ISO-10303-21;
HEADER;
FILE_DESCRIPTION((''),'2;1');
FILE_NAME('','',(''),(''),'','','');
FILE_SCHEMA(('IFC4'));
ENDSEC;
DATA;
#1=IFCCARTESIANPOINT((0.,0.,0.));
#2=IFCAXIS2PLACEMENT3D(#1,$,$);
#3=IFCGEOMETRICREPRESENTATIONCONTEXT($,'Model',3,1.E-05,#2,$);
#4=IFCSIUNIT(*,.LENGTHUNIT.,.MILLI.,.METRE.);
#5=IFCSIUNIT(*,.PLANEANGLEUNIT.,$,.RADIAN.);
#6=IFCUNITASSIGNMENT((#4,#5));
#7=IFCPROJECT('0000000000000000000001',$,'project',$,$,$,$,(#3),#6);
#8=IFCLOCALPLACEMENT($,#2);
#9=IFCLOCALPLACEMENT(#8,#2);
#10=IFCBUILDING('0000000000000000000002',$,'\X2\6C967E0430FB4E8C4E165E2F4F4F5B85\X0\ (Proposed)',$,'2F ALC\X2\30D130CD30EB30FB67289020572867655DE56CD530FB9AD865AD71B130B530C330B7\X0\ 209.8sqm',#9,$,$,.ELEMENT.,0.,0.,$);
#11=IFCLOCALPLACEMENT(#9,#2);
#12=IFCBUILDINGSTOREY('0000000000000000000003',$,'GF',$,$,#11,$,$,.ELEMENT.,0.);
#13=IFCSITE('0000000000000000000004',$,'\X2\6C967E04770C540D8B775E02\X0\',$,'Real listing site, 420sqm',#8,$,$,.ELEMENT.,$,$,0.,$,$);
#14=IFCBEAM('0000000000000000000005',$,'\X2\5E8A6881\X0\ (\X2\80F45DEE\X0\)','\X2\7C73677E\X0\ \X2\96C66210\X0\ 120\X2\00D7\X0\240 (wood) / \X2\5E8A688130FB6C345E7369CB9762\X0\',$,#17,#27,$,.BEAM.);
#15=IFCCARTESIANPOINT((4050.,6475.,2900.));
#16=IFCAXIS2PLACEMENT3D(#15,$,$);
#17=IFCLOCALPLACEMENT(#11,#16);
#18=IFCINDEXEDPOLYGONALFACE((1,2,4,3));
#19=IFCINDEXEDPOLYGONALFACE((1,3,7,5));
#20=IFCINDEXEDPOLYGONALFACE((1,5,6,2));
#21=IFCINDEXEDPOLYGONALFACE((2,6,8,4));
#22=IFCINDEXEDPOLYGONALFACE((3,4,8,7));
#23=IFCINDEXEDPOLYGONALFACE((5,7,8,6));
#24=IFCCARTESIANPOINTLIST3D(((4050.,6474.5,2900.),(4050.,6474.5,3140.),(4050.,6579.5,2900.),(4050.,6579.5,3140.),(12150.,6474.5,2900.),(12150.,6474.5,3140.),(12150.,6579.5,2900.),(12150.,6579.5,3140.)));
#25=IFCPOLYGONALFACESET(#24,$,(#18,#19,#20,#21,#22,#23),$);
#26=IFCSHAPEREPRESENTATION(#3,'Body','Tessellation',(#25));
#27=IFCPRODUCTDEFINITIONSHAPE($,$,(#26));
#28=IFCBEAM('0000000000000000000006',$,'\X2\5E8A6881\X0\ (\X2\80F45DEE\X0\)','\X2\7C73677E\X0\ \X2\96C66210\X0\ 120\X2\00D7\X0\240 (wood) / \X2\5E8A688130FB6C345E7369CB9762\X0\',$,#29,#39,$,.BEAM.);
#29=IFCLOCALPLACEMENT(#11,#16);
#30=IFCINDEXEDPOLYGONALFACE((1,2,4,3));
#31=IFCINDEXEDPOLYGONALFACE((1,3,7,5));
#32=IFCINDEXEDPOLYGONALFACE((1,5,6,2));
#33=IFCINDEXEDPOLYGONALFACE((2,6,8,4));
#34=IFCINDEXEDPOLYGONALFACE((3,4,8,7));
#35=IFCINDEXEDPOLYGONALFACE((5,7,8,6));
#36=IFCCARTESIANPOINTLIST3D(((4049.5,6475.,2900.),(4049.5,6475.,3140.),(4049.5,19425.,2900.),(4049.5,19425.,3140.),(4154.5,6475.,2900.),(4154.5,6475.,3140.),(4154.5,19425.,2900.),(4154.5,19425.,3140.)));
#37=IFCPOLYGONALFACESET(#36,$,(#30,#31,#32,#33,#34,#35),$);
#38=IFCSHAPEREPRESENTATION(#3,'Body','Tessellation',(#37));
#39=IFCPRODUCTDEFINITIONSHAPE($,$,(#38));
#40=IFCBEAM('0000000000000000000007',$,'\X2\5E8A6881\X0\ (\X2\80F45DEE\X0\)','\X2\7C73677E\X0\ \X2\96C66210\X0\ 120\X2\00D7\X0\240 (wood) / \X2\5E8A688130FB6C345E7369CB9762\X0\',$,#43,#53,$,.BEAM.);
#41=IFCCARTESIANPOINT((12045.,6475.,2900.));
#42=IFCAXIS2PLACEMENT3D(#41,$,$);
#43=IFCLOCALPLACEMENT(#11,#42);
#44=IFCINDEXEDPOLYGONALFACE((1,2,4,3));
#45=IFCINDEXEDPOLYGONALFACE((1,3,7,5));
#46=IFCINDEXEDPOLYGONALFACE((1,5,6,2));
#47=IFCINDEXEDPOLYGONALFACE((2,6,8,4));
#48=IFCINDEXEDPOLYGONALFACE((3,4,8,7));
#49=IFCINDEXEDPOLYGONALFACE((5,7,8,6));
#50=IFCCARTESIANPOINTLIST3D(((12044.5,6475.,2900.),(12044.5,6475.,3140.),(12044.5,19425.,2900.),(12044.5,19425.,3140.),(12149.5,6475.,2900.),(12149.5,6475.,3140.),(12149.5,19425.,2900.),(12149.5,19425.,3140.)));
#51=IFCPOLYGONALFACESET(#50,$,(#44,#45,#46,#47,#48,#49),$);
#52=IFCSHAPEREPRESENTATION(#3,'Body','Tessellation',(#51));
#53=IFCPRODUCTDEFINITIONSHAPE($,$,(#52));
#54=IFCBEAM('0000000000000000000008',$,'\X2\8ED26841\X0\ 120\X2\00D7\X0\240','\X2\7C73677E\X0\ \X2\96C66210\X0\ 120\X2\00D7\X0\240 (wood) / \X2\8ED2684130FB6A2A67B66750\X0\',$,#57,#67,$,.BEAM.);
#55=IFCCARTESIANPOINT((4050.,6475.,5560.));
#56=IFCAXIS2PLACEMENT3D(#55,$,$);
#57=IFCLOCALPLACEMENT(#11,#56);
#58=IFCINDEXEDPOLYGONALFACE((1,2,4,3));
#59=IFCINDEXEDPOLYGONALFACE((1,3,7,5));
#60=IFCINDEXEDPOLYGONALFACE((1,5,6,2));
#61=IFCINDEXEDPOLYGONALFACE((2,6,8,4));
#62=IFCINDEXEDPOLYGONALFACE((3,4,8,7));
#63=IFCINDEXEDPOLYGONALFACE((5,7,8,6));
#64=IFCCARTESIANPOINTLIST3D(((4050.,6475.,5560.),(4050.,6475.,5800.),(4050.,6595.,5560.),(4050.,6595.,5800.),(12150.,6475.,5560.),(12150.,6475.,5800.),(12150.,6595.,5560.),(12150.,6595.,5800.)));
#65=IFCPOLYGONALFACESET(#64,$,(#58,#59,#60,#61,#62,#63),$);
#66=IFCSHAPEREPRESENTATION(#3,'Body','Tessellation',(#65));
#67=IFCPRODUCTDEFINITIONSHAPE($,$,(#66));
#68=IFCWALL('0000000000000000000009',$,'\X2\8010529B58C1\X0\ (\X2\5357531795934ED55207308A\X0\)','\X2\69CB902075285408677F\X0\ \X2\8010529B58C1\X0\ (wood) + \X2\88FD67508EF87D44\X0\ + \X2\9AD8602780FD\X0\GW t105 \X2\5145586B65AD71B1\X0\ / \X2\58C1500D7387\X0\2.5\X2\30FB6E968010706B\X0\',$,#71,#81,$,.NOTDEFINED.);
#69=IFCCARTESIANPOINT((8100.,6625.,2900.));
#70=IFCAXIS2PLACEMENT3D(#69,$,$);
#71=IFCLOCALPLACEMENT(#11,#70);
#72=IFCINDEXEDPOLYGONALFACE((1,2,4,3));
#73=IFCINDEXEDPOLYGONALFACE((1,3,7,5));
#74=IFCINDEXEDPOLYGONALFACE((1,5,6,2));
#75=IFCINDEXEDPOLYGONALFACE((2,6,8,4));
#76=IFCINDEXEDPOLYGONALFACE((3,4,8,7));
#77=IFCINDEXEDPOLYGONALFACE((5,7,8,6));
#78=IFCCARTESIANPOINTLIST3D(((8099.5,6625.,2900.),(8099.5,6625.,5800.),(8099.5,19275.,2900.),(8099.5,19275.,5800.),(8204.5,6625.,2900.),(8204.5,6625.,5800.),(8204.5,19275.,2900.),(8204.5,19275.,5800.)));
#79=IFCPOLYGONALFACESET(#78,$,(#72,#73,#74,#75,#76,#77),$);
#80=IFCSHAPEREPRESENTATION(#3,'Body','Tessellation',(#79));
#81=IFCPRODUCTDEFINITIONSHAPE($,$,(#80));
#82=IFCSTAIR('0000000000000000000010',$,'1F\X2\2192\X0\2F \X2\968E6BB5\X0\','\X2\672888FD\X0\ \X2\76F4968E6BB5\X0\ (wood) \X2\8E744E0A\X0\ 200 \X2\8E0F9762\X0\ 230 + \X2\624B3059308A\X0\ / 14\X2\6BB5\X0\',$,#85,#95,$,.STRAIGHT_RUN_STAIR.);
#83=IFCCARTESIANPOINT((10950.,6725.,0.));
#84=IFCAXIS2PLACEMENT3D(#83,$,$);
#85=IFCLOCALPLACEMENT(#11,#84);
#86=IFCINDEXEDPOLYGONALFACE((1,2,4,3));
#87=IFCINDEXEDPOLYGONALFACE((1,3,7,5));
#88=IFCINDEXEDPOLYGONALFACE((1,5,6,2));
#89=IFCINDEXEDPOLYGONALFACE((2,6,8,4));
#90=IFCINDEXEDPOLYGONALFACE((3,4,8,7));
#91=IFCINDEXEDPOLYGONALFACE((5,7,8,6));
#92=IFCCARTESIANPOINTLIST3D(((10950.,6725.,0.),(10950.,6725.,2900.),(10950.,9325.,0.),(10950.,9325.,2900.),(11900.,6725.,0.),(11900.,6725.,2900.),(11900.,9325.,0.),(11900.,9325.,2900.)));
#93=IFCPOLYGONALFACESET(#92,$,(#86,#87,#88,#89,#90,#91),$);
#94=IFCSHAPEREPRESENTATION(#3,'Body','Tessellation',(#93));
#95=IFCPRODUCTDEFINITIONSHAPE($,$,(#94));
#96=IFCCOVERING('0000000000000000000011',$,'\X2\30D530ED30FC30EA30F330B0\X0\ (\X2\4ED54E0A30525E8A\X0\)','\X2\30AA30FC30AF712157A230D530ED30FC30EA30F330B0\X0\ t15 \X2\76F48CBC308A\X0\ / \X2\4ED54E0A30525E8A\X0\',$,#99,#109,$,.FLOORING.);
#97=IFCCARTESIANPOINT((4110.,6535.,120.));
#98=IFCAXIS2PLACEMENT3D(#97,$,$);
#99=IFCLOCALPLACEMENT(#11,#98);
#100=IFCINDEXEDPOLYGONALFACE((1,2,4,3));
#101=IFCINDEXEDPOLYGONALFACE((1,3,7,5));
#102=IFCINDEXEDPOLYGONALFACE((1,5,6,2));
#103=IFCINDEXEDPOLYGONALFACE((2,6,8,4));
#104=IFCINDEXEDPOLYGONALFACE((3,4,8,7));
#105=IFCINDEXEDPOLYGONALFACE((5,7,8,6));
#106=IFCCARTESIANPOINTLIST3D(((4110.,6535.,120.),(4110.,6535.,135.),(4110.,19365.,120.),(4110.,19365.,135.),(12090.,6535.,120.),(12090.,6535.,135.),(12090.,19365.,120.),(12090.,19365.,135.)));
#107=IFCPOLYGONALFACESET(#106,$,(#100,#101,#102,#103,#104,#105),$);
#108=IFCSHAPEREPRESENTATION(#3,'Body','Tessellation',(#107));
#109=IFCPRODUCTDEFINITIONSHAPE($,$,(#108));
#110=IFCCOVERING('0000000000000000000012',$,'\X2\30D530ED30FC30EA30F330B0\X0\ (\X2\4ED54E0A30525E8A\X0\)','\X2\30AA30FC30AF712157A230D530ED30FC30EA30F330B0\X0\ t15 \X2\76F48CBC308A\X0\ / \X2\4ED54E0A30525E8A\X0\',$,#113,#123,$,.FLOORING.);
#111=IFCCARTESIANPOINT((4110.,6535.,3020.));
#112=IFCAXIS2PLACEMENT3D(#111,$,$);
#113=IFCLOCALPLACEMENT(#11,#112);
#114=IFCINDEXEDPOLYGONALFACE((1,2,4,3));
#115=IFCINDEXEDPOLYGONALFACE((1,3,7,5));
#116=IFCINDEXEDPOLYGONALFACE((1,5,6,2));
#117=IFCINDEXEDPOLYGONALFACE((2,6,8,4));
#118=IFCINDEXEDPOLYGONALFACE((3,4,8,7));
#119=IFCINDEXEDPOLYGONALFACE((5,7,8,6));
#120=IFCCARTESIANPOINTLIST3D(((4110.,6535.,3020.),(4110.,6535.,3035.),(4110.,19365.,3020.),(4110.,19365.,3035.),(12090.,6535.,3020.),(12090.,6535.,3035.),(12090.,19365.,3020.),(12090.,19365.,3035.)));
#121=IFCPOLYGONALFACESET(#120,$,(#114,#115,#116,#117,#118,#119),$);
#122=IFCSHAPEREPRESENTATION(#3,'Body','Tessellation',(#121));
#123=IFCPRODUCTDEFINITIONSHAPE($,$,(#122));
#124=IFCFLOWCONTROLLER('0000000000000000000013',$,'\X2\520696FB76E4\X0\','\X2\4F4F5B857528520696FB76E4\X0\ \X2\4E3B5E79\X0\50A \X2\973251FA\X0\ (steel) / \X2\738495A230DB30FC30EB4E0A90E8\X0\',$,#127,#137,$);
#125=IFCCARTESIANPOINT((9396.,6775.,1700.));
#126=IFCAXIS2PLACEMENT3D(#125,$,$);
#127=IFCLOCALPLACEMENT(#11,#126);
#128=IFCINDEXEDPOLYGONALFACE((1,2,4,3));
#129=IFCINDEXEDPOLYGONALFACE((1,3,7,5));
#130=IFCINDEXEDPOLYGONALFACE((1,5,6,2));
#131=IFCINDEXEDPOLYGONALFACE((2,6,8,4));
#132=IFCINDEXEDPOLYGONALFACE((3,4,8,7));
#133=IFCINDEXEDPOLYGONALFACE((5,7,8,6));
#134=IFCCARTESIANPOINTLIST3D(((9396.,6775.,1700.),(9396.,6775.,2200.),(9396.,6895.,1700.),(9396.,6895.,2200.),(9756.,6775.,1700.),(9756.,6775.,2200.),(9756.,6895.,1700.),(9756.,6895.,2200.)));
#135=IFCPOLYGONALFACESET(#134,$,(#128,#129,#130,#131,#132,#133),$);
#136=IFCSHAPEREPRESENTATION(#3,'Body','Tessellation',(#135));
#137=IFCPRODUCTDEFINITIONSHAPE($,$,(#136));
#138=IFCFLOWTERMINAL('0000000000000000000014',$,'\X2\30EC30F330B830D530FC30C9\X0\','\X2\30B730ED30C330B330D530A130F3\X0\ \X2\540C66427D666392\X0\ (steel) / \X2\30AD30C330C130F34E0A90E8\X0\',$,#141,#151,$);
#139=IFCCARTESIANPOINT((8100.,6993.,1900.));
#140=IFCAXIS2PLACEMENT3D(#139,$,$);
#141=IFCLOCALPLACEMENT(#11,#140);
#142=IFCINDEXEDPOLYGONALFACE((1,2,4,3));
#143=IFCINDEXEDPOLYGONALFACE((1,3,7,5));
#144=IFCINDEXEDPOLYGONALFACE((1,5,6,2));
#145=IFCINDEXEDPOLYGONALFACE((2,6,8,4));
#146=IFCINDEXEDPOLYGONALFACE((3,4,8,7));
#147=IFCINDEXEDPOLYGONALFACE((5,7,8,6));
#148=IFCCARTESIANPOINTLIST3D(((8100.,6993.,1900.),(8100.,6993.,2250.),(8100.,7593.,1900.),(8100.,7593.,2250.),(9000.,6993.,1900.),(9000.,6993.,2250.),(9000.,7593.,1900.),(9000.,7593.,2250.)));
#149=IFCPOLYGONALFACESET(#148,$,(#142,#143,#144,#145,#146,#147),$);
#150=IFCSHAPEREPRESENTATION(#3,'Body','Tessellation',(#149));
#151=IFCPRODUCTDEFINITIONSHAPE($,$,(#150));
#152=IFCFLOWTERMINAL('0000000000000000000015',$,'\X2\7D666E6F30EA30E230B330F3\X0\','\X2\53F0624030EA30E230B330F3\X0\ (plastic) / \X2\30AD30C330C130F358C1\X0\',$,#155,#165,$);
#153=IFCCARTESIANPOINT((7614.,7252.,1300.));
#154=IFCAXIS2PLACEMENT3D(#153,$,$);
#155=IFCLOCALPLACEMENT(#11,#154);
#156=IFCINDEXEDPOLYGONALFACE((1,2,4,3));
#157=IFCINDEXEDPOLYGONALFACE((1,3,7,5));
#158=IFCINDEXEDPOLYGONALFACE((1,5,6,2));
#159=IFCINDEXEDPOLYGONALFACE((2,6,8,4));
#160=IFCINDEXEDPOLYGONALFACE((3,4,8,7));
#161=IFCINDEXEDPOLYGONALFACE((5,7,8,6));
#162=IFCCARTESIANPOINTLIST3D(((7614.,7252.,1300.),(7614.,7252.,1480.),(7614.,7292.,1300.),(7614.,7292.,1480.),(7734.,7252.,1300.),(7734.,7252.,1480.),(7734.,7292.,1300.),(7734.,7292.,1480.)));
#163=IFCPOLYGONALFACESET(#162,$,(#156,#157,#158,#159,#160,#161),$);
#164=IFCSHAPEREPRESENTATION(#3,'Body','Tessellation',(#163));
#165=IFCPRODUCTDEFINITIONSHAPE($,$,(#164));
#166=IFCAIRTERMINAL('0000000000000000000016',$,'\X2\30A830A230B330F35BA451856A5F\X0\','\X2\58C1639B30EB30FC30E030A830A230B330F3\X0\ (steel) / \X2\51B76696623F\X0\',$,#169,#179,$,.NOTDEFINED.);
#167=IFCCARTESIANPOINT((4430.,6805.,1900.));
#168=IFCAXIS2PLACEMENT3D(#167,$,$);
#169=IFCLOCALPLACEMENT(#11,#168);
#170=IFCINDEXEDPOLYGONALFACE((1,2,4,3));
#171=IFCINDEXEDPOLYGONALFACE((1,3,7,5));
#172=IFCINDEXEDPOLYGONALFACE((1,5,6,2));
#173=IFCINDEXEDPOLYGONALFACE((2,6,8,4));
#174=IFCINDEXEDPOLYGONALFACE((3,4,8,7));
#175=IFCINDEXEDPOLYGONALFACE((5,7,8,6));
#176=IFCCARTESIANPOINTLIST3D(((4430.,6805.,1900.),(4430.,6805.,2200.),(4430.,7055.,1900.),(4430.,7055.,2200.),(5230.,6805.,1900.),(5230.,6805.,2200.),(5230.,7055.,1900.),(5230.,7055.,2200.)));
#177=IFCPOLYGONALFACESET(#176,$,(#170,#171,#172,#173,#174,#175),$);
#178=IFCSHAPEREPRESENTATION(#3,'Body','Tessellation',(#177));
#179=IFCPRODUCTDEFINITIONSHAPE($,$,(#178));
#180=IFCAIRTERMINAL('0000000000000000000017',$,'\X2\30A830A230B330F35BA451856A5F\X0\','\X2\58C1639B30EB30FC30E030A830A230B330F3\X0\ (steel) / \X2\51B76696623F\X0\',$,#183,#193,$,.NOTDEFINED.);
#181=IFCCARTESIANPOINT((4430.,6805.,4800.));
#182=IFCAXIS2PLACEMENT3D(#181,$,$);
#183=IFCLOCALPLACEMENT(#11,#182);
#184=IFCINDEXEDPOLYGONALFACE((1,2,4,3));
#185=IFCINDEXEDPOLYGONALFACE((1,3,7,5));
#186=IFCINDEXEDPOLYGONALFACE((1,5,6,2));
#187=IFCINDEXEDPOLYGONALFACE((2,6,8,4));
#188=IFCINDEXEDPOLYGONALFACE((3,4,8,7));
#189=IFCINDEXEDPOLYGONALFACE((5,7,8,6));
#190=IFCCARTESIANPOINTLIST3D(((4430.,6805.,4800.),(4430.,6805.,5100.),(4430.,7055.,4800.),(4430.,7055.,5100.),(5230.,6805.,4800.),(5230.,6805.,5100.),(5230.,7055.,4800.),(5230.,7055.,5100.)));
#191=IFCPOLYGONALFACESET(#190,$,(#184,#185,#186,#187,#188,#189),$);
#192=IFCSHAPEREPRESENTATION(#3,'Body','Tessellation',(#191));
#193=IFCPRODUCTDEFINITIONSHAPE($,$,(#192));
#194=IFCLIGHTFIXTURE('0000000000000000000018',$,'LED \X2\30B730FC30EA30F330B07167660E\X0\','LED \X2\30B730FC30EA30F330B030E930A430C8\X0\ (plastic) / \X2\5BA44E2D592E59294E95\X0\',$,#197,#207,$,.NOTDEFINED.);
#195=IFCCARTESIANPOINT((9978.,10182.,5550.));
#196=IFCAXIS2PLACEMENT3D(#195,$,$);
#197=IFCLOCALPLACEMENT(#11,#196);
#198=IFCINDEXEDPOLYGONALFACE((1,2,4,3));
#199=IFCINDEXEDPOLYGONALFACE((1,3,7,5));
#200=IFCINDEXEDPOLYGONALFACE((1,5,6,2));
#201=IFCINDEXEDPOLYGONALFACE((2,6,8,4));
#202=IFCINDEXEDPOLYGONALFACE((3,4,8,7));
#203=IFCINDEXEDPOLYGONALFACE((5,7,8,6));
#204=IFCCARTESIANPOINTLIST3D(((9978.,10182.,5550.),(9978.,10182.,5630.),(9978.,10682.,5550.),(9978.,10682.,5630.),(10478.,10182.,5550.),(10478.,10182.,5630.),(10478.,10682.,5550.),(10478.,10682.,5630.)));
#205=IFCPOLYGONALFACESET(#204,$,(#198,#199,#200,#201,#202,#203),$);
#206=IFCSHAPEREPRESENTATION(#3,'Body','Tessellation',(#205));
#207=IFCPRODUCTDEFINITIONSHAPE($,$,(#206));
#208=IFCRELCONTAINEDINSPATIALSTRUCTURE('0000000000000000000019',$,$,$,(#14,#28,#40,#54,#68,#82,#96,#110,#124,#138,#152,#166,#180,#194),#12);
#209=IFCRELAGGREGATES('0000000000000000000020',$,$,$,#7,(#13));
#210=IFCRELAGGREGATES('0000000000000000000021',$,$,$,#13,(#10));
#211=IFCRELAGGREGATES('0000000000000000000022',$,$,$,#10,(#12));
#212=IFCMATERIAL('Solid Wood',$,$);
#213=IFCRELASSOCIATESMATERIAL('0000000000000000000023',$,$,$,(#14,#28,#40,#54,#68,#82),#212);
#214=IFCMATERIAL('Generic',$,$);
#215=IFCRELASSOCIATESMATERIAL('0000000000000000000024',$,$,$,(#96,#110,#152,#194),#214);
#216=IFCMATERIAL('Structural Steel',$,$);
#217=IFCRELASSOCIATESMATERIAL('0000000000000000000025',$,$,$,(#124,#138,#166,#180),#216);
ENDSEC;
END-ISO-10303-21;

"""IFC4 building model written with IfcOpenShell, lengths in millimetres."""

from ifc_helpers import new_model, si_unit, frame, frame_2d, origin, place, context, project, spatial, rectangle, extrude, material, element, save


model = new_model("IFC4")

# Units and contexts
model_context = context("Model", 3, precision=1e-05, world=origin())
ifc_project = project(units=[si_unit("LENGTHUNIT", "METRE", prefix="MILLI"), si_unit("PLANEANGLEUNIT", "RADIAN")], contexts=[model_context])

# Site, building, storey
site_placement = place(None, origin())
site = spatial("IfcSite", under=ifc_project, at=site_placement, Name="沖縄県名護市", ObjectType="Real listing site, 420sqm", CompositionType="ELEMENT", RefElevation=0.0)
building_placement = place(site_placement, origin())
building = spatial("IfcBuilding", under=site, at=building_placement, Name="沖縄・二世帯住宅 (Proposed)", ObjectType="2F ALCパネル・木造在来工法・高断熱サッシ 209.8sqm", CompositionType="ELEMENT", ElevationOfRefHeight=0.0, ElevationOfTerrain=0.0)
storey_placement = place(building_placement, origin())
storey = spatial("IfcBuildingStorey", under=building, at=storey_placement, Name="GF", CompositionType="ELEMENT", Elevation=0.0)

# Shared definitions
ifc_material_1 = material(Name="Solid Wood")

# Beams
beam_1_placement = place(storey_placement, frame((4050.0, 6475.0, 2900.0)))
element("IfcBeam", 1, at=beam_1_placement, inside=storey, material=ifc_material_1, Name="床梁 (胴差)", Description="米松 集成 120×240 (wood) / 床梁・水平構面", PredefinedType="BEAM", context=model_context, shape_type="SweptSolid", body=[
    extrude(rectangle(XDim=8100.0, YDim=105.0, at=frame_2d((4050.0, 52.0))), frame((4050.0, 6475.0, 2900.0)), (0.0, 0.0, 1.0), 240.0),
])
beam_2_placement = place(storey_placement, frame((4050.0, 6475.0, 2900.0)))
element("IfcBeam", 2, at=beam_2_placement, inside=storey, material=ifc_material_1, Name="床梁 (胴差)", Description="米松 集成 120×240 (wood) / 床梁・水平構面", PredefinedType="BEAM", context=model_context, shape_type="SweptSolid", body=[
    extrude(rectangle(XDim=105.0, YDim=12950.0, at=frame_2d((52.0, 6475.0))), frame((4050.0, 6475.0, 2900.0)), (0.0, 0.0, 1.0), 240.0),
])
beam_3_placement = place(storey_placement, frame((12045.0, 6475.0, 2900.0)))
element("IfcBeam", 3, at=beam_3_placement, inside=storey, material=ifc_material_1, Name="床梁 (胴差)", Description="米松 集成 120×240 (wood) / 床梁・水平構面", PredefinedType="BEAM", context=model_context, shape_type="SweptSolid", body=[
    extrude(rectangle(XDim=105.0, YDim=12950.0, at=frame_2d((52.0, 6475.0))), frame((12045.0, 6475.0, 2900.0)), (0.0, 0.0, 1.0), 240.0),
])
beam_4_placement = place(storey_placement, frame((4050.0, 6475.0, 5560.0)))
element("IfcBeam", 4, at=beam_4_placement, inside=storey, material=ifc_material_1, Name="軒桁 120×240", Description="米松 集成 120×240 (wood) / 軒桁・横架材", PredefinedType="BEAM", context=model_context, shape_type="SweptSolid", body=[
    extrude(rectangle(XDim=8100.0, YDim=120.0, at=frame_2d((4050.0, 60.0))), frame((4050.0, 6475.0, 5560.0)), (0.0, 0.0, 1.0), 240.0),
])

# Wall
wall_1_placement = place(storey_placement, frame((8100.0, 6625.0, 2900.0)))
element("IfcWall", 5, at=wall_1_placement, inside=storey, material=ifc_material_1, Name="耐力壁 (南北間仕切り)", Description="構造用合板 耐力壁 (wood) + 製材軸組 + 高性能GW t105 充填断熱 / 壁倍率2.5・準耐火", PredefinedType="NOTDEFINED", context=model_context, shape_type="SweptSolid", body=[
    extrude(rectangle(XDim=105.0, YDim=12650.0, at=frame_2d((52.0, 6325.0))), frame((8100.0, 6625.0, 2900.0)), (0.0, 0.0, 1.0), 2900.0),
])

# Stair
stair_placement = place(storey_placement, frame((10950.0, 6725.0, 0.0)))
element("IfcStair", 6, at=stair_placement, inside=storey, material=ifc_material_1, Name="1F→2F 階段", Description="木製 直階段 (wood) 蹴上 200 踏面 230 + 手すり / 14段", PredefinedType="STRAIGHT_RUN_STAIR", context=model_context, shape_type="SweptSolid", body=[
    extrude(rectangle(XDim=950.0, YDim=2600.0, at=frame_2d((475.0, 1300.0))), frame((10950.0, 6725.0, 0.0)), (0.0, 0.0, 1.0), 2900.0),
])

# Coverings
ifc_material_2 = material(Name="Generic")
covering_1_placement = place(storey_placement, frame((4110.0, 6535.0, 120.0)))
element("IfcCovering", 7, at=covering_1_placement, inside=storey, material=ifc_material_2, Name="フローリング (仕上げ床)", Description="オーク無垢フローリング t15 直貼り / 仕上げ床", PredefinedType="FLOORING", context=model_context, shape_type="SweptSolid", body=[
    extrude(rectangle(XDim=7980.0, YDim=12830.0, at=frame_2d((3990.0, 6415.0))), frame((4110.0, 6535.0, 120.0)), (0.0, 0.0, 1.0), 15.0),
])
covering_2_placement = place(storey_placement, frame((4110.0, 6535.0, 3020.0)))
element("IfcCovering", 8, at=covering_2_placement, inside=storey, material=ifc_material_2, Name="フローリング (仕上げ床)", Description="オーク無垢フローリング t15 直貼り / 仕上げ床", PredefinedType="FLOORING", context=model_context, shape_type="SweptSolid", body=[
    extrude(rectangle(XDim=7980.0, YDim=12830.0, at=frame_2d((3990.0, 6415.0))), frame((4110.0, 6535.0, 3020.0)), (0.0, 0.0, 1.0), 15.0),
])

# Flow controller
ifc_material_3 = material(Name="Structural Steel")
flow_controller_placement = place(storey_placement, frame((9396.0, 6775.0, 1700.0)))
element("IfcFlowController", 9, at=flow_controller_placement, inside=storey, material=ifc_material_3, Name="分電盤", Description="住宅用分電盤 主幹50A 露出 (steel) / 玄関ホール上部", context=model_context, shape_type="SweptSolid", body=[
    extrude(rectangle(XDim=360.0, YDim=120.0, at=frame_2d((180.0, 60.0))), frame((9396.0, 6775.0, 1700.0)), (0.0, 0.0, 1.0), 500.0),
])

# Flow terminals
flow_terminal_1_placement = place(storey_placement, frame((8100.0, 6993.0, 1900.0)))
element("IfcFlowTerminal", 10, at=flow_terminal_1_placement, inside=storey, material=ifc_material_3, Name="レンジフード", Description="シロッコファン 同時給排 (steel) / キッチン上部", context=model_context, shape_type="SweptSolid", body=[
    extrude(rectangle(XDim=900.0, YDim=600.0, at=frame_2d((450.0, 300.0))), frame((8100.0, 6993.0, 1900.0)), (0.0, 0.0, 1.0), 350.0),
])
flow_terminal_2_placement = place(storey_placement, frame((7614.0, 7252.0, 1300.0)))
element("IfcFlowTerminal", 11, at=flow_terminal_2_placement, inside=storey, material=ifc_material_2, Name="給湯リモコン", Description="台所リモコン (plastic) / キッチン壁", context=model_context, shape_type="SweptSolid", body=[
    extrude(rectangle(XDim=120.0, YDim=40.0, at=frame_2d((60.0, 20.0))), frame((7614.0, 7252.0, 1300.0)), (0.0, 0.0, 1.0), 180.0),
])

# Air terminals
air_terminal_1_placement = place(storey_placement, frame((4430.0, 6805.0, 1900.0)))
element("IfcAirTerminal", 12, at=air_terminal_1_placement, inside=storey, material=ifc_material_3, Name="エアコン室内機", Description="壁掛ルームエアコン (steel) / 冷暖房", PredefinedType="NOTDEFINED", context=model_context, shape_type="SweptSolid", body=[
    extrude(rectangle(XDim=800.0, YDim=250.0, at=frame_2d((400.0, 125.0))), frame((4430.0, 6805.0, 1900.0)), (0.0, 0.0, 1.0), 300.0),
])
air_terminal_2_placement = place(storey_placement, frame((4430.0, 6805.0, 4800.0)))
element("IfcAirTerminal", 13, at=air_terminal_2_placement, inside=storey, material=ifc_material_3, Name="エアコン室内機", Description="壁掛ルームエアコン (steel) / 冷暖房", PredefinedType="NOTDEFINED", context=model_context, shape_type="SweptSolid", body=[
    extrude(rectangle(XDim=800.0, YDim=250.0, at=frame_2d((400.0, 125.0))), frame((4430.0, 6805.0, 4800.0)), (0.0, 0.0, 1.0), 300.0),
])

# Light fixture
light_fixture_placement = place(storey_placement, frame((9978.0, 10182.0, 5550.0)))
element("IfcLightFixture", 14, at=light_fixture_placement, inside=storey, material=ifc_material_2, Name="LED シーリング照明", Description="LED シーリングライト (plastic) / 室中央天井", PredefinedType="NOTDEFINED", context=model_context, shape_type="SweptSolid", body=[
    extrude(rectangle(XDim=500.0, YDim=500.0, at=frame_2d((250.0, 250.0))), frame((9978.0, 10182.0, 5550.0)), (0.0, 0.0, 1.0), 80.0),
])

save(model, "model.ifc")
